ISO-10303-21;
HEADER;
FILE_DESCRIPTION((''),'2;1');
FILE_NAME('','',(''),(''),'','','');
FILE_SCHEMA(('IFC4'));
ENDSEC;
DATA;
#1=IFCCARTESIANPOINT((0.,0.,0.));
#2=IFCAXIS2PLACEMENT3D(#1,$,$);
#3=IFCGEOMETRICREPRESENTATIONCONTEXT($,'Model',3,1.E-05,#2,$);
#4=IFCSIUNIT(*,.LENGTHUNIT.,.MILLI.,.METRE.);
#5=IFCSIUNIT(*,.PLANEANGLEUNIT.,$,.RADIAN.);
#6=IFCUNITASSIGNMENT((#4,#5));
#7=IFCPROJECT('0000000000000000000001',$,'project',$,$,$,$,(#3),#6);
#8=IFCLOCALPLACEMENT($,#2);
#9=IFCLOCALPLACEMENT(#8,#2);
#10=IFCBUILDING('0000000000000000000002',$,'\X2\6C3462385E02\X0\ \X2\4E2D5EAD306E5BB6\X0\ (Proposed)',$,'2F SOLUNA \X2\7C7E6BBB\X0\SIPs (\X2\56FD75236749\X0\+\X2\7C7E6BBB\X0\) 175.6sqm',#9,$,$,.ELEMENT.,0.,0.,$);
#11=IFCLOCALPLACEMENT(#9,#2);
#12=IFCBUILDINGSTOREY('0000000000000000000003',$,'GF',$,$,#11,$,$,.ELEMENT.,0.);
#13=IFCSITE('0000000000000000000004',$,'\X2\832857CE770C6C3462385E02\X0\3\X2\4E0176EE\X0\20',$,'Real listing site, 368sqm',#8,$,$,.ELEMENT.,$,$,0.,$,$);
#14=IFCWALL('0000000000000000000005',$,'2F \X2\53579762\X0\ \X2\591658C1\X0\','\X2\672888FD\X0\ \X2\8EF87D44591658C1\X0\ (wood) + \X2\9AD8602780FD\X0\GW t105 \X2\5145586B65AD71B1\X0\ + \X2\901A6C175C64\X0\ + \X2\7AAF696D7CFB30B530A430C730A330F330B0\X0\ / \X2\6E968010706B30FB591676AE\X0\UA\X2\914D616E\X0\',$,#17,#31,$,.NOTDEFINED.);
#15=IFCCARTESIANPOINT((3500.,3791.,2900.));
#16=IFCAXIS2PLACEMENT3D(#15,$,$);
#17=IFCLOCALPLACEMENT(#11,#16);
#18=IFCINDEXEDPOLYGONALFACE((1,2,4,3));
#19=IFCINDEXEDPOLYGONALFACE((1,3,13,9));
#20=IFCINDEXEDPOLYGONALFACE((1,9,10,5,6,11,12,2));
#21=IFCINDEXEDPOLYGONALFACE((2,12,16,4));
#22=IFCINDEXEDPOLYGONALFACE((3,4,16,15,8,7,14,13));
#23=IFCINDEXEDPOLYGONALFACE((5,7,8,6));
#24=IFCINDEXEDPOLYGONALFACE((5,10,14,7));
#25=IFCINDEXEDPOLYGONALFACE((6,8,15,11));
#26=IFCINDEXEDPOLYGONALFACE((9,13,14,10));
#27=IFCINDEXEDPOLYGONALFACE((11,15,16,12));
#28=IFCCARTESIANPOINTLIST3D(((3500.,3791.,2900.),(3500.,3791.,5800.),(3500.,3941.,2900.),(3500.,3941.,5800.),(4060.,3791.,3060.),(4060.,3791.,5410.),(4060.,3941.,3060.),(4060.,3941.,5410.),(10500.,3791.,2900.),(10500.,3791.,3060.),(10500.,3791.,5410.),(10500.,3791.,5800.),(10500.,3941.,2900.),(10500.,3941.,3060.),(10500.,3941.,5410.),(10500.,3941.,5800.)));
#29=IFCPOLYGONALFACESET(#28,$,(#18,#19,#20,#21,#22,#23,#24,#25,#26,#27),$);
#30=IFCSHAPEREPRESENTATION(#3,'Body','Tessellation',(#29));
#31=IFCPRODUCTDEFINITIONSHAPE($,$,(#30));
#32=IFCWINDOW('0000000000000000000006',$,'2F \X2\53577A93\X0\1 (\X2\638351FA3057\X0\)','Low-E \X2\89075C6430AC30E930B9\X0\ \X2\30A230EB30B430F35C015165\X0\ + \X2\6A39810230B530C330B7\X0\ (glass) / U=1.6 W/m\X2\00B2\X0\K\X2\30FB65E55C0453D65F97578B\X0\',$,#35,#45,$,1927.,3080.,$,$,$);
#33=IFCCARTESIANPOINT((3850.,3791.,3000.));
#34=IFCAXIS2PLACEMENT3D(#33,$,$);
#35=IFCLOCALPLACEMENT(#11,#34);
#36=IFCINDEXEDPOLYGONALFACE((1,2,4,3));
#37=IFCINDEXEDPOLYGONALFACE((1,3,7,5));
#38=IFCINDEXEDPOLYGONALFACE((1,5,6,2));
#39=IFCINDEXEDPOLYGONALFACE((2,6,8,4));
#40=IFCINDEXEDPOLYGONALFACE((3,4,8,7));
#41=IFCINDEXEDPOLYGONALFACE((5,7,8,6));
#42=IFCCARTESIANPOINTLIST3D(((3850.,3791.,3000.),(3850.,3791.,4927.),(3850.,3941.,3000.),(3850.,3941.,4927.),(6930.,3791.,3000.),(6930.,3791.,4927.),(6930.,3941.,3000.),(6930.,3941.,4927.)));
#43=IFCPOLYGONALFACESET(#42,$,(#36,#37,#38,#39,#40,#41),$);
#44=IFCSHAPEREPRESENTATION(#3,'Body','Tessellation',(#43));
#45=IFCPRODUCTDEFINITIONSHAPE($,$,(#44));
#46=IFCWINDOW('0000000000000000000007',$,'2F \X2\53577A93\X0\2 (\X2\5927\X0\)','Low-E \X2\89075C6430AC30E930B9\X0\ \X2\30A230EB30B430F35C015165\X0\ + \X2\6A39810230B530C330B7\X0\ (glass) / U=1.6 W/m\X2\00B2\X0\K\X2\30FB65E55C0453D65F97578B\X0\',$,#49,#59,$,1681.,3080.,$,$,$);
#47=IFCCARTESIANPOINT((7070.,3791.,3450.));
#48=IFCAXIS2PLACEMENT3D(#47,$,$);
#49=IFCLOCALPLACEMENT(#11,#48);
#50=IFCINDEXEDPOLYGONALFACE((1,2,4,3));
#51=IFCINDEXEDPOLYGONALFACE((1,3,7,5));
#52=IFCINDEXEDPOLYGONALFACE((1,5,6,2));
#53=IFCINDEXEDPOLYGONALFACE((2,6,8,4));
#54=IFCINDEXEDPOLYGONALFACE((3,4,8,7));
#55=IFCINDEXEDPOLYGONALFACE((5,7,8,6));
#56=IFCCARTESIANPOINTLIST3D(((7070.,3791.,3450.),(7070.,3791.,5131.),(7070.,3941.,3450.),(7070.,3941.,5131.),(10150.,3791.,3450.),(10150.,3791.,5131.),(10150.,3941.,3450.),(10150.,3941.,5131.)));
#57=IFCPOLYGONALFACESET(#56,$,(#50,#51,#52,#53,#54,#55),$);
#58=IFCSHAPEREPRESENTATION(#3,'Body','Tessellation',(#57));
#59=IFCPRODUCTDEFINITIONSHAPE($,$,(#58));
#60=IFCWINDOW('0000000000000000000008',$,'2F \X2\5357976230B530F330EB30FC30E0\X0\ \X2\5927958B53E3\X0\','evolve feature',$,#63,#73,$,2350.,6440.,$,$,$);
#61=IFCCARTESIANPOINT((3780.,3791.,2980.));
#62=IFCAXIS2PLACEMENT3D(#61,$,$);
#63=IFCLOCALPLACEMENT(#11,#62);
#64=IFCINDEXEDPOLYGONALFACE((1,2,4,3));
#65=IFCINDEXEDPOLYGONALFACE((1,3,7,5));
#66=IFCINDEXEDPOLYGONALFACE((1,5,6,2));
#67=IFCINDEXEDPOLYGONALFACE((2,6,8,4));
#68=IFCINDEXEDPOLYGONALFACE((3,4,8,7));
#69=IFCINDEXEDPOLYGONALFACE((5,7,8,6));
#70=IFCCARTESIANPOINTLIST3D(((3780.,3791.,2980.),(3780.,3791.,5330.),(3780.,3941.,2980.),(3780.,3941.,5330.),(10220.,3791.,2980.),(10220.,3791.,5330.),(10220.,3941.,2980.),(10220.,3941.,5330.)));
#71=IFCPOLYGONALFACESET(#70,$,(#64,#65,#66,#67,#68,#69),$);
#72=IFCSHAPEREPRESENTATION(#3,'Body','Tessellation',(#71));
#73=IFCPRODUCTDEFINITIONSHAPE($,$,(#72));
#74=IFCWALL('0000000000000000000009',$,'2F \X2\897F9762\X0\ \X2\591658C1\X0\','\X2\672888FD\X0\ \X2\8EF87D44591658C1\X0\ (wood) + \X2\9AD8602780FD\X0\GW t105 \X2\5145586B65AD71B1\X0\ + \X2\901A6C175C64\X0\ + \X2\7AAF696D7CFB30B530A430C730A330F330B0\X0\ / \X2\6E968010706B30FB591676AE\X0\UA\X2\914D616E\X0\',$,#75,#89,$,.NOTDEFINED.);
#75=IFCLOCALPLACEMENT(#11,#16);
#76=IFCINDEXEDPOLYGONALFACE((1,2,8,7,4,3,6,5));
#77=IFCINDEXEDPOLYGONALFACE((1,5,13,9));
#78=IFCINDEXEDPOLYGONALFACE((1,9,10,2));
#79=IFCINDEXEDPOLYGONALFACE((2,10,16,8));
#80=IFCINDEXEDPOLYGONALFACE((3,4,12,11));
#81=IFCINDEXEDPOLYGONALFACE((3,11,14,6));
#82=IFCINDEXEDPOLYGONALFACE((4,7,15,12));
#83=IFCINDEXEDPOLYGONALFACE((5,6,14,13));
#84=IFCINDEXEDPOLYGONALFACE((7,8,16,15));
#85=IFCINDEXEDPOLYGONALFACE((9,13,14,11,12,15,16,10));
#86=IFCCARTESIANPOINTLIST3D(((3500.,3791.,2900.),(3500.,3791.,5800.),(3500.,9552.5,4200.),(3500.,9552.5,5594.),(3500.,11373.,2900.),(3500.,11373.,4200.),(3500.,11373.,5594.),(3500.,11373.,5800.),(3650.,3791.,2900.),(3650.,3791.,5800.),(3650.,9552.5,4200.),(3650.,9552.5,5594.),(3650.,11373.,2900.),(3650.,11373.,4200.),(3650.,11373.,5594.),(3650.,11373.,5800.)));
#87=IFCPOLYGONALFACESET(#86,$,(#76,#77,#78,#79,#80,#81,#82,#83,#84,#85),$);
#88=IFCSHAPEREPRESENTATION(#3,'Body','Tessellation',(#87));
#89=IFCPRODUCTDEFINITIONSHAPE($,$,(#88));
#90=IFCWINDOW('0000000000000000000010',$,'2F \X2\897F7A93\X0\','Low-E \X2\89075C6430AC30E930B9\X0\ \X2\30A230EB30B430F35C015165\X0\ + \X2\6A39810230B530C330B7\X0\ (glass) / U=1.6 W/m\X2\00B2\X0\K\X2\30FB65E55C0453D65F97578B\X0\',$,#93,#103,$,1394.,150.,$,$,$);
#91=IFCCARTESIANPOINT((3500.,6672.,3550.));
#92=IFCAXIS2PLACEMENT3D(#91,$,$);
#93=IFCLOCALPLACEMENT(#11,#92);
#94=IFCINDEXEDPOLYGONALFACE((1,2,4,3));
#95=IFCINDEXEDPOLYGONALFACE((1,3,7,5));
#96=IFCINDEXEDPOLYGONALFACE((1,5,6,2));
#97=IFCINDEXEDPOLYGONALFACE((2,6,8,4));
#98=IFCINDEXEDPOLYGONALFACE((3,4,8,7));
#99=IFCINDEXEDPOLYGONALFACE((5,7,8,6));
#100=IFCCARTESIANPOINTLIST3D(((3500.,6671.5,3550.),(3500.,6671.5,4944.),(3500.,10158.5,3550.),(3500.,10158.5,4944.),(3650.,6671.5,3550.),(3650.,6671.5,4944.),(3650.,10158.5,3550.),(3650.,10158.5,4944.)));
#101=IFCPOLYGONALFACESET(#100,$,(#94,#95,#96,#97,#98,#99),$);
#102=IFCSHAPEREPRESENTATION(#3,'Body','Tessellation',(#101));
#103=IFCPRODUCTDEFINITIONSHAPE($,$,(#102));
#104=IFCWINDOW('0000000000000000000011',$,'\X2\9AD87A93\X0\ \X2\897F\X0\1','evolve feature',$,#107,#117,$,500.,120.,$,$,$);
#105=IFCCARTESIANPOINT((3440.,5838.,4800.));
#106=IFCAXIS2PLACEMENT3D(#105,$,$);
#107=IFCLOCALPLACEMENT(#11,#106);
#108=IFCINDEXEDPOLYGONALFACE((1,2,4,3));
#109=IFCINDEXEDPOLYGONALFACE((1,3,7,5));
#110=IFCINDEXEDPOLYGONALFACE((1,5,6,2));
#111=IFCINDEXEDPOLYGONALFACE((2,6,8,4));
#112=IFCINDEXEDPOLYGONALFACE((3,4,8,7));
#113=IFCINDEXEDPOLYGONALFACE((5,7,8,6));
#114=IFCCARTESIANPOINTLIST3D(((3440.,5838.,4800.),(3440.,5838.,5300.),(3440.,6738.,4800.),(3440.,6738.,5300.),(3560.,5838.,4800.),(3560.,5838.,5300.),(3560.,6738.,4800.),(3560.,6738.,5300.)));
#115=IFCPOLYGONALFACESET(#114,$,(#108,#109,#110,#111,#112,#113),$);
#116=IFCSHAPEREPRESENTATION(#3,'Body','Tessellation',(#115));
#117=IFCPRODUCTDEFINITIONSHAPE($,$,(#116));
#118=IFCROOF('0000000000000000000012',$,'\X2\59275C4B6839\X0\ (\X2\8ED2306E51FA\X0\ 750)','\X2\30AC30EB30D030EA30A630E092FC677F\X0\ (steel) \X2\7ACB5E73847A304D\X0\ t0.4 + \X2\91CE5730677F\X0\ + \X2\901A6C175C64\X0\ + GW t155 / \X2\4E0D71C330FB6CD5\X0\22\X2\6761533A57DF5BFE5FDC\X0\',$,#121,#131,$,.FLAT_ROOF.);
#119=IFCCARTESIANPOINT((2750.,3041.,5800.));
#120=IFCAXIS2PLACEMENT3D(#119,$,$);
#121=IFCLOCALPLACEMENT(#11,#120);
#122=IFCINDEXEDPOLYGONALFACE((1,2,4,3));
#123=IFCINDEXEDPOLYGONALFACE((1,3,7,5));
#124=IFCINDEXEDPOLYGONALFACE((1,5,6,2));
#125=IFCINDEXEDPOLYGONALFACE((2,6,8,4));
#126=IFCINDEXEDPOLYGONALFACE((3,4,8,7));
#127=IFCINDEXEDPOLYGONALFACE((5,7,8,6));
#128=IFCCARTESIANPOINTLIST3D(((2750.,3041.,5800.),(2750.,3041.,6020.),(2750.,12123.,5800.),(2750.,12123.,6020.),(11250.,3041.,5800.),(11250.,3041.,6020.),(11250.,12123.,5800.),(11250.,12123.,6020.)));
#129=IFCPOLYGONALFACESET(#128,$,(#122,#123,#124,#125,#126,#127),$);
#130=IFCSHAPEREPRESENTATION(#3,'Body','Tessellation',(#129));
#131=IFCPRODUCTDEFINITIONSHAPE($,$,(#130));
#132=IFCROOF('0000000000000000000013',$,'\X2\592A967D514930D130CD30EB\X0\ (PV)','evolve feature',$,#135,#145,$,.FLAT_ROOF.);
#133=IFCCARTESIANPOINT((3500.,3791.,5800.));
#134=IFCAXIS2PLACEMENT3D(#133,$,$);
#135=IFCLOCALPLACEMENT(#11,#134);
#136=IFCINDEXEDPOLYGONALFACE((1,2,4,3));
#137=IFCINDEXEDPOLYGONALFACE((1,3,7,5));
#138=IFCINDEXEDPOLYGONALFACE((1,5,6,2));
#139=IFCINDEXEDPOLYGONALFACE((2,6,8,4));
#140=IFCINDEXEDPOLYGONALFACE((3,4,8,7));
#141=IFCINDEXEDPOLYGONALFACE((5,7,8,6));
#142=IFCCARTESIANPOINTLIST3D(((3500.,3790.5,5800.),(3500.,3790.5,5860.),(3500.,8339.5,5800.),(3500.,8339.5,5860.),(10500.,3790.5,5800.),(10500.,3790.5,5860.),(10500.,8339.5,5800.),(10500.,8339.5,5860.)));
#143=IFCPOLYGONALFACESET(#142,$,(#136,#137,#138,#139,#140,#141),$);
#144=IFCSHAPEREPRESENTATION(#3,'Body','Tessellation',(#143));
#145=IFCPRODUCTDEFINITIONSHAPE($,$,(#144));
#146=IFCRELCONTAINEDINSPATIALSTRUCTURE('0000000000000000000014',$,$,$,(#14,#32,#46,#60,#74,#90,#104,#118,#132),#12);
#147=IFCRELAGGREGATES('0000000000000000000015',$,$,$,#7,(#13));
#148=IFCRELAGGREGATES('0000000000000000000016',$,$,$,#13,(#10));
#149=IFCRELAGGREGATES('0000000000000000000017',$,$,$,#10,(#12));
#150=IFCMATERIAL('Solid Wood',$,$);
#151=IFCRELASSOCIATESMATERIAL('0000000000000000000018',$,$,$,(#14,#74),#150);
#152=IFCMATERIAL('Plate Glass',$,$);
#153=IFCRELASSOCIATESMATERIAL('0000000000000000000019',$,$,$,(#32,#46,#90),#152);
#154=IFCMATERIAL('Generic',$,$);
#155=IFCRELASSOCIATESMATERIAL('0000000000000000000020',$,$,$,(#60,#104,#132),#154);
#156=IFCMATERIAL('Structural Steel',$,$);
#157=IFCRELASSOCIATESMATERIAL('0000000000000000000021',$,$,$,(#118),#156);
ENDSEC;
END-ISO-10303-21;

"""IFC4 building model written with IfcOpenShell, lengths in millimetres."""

from ifc_helpers import new_model, si_unit, frame, frame_2d, origin, place, context, project, spatial, rectangle, extrude, material, element, fill, save


model = new_model("IFC4")

# Units and contexts
model_context = context("Model", 3, precision=1e-05, world=origin())
ifc_project = project(units=[si_unit("LENGTHUNIT", "METRE", prefix="MILLI"), si_unit("PLANEANGLEUNIT", "RADIAN")], contexts=[model_context])

# Site, building, storey
site_placement = place(None, origin())
site = spatial("IfcSite", under=ifc_project, at=site_placement, Name="茨城県水戸市3丁目20", ObjectType="Real listing site, 368sqm", CompositionType="ELEMENT", RefElevation=0.0)
building_placement = place(site_placement, origin())
building = spatial("IfcBuilding", under=site, at=building_placement, Name="水戸市 中庭の家 (Proposed)", ObjectType="2F SOLUNA 籾殻SIPs (国産杉+籾殻) 175.6sqm", CompositionType="ELEMENT", ElevationOfRefHeight=0.0, ElevationOfTerrain=0.0)
storey_placement = place(building_placement, origin())
storey = spatial("IfcBuildingStorey", under=building, at=storey_placement, Name="GF", CompositionType="ELEMENT", Elevation=0.0)

# Shared definitions
ifc_material_1 = material(Name="Solid Wood")
ifc_material_2 = material(Name="Generic")

# Shared definitions
ifc_material_3 = material(Name="Plate Glass")

# Walls, openings, windows
wall_1_placement = place(storey_placement, frame((3500.0, 3791.0, 2900.0)))
wall_1 = element("IfcWall", 1, at=wall_1_placement, inside=storey, material=ifc_material_1, Name="2F 南面 外壁", Description="木製 軸組外壁 (wood) + 高性能GW t105 充填断熱 + 通気層 + 窯業系サイディング / 準耐火・外皮UA配慮", PredefinedType="NOTDEFINED", context=model_context, shape_type="SweptSolid", body=[
    extrude(rectangle(XDim=7000.0, YDim=150.0, at=frame_2d((3500.0, 75.0))), frame((3500.0, 3791.0, 2900.0)), (0.0, 0.0, 1.0), 2900.0),
])
opening_1_placement = place(storey_placement, frame((3850.0, 3791.0, 3000.0)))
opening_1 = element("IfcOpeningElement", 2, at=opening_1_placement, cuts=wall_1, PredefinedType="NOTDEFINED", context=model_context, shape_type="SweptSolid", body=[
    extrude(rectangle(XDim=3080.0, YDim=150.0, at=frame_2d((1540.0, 75.0))), frame((3850.0, 3791.0, 3000.0)), (0.0, 0.0, 1.0), 1927.0),
])
opening_2_placement = place(storey_placement, frame((7070.0, 3791.0, 3450.0)))
opening_2 = element("IfcOpeningElement", 3, at=opening_2_placement, cuts=wall_1, PredefinedType="NOTDEFINED", context=model_context, shape_type="SweptSolid", body=[
    extrude(rectangle(XDim=3080.0, YDim=150.0, at=frame_2d((1540.0, 75.0))), frame((7070.0, 3791.0, 3450.0)), (0.0, 0.0, 1.0), 1681.0),
])
opening_3_placement = place(storey_placement, frame((3780.0, 3791.0, 2980.0)))
opening_3 = element("IfcOpeningElement", 4, at=opening_3_placement, cuts=wall_1, PredefinedType="NOTDEFINED", context=model_context, shape_type="SweptSolid", body=[
    extrude(rectangle(XDim=6440.0, YDim=150.0, at=frame_2d((3220.0, 75.0))), frame((3780.0, 3791.0, 2980.0)), (0.0, 0.0, 1.0), 2350.0),
])
window_1_placement = place(storey_placement, frame((3850.0, 3791.0, 3000.0)))
window_1 = element("IfcWindow", 5, at=window_1_placement, inside=storey, material=ifc_material_3, Name="2F 南窓1 (掃出し)", Description="Low-E 複層ガラス アルゴン封入 + 樹脂サッシ (glass) / U=1.6 W/m²K・日射取得型", OverallHeight=1927.0, OverallWidth=3080.0, context=model_context, shape_type="SweptSolid", body=[
    extrude(rectangle(XDim=3080.0, YDim=150.0, at=frame_2d((1540.0, 75.0))), frame((3850.0, 3791.0, 3000.0)), (0.0, 0.0, 1.0), 1927.0),
])
fill(opening_1, window_1)
window_2_placement = place(storey_placement, frame((7070.0, 3791.0, 3450.0)))
window_2 = element("IfcWindow", 6, at=window_2_placement, inside=storey, material=ifc_material_3, Name="2F 南窓2 (大)", Description="Low-E 複層ガラス アルゴン封入 + 樹脂サッシ (glass) / U=1.6 W/m²K・日射取得型", OverallHeight=1681.0, OverallWidth=3080.0, context=model_context, shape_type="SweptSolid", body=[
    extrude(rectangle(XDim=3080.0, YDim=150.0, at=frame_2d((1540.0, 75.0))), frame((7070.0, 3791.0, 3450.0)), (0.0, 0.0, 1.0), 1681.0),
])
fill(opening_2, window_2)
window_3_placement = place(storey_placement, frame((3780.0, 3791.0, 2980.0)))
window_3 = element("IfcWindow", 7, at=window_3_placement, inside=storey, material=ifc_material_2, Name="2F 南面サンルーム 大開口", Description="evolve feature", OverallHeight=2350.0, OverallWidth=6440.0, context=model_context, shape_type="SweptSolid", body=[
    extrude(rectangle(XDim=6440.0, YDim=150.0, at=frame_2d((3220.0, 75.0))), frame((3780.0, 3791.0, 2980.0)), (0.0, 0.0, 1.0), 2350.0),
])
fill(opening_3, window_3)
wall_2_placement = place(storey_placement, frame((3500.0, 3791.0, 2900.0)))
wall_2 = element("IfcWall", 8, at=wall_2_placement, inside=storey, material=ifc_material_1, Name="2F 西面 外壁", Description="木製 軸組外壁 (wood) + 高性能GW t105 充填断熱 + 通気層 + 窯業系サイディング / 準耐火・外皮UA配慮", PredefinedType="NOTDEFINED", context=model_context, shape_type="SweptSolid", body=[
    extrude(rectangle(XDim=150.0, YDim=7582.0, at=frame_2d((75.0, 3791.0))), frame((3500.0, 3791.0, 2900.0)), (0.0, 0.0, 1.0), 2900.0),
])
opening_4_placement = place(storey_placement, frame((3500.0, 6672.0, 3550.0)))
opening_4 = element("IfcOpeningElement", 9, at=opening_4_placement, cuts=wall_2, PredefinedType="NOTDEFINED", context=model_context, shape_type="SweptSolid", body=[
    extrude(rectangle(XDim=150.0, YDim=3487.0, at=frame_2d((75.0, 1743.0))), frame((3500.0, 6672.0, 3550.0)), (0.0, 0.0, 1.0), 1394.0),
])
opening_5_placement = place(storey_placement, frame((3440.0, 5838.0, 4800.0)))
opening_5 = element("IfcOpeningElement", 10, at=opening_5_placement, cuts=wall_2, PredefinedType="NOTDEFINED", context=model_context, shape_type="SweptSolid", body=[
    extrude(rectangle(XDim=120.0, YDim=900.0, at=frame_2d((60.0, 450.0))), frame((3440.0, 5838.0, 4800.0)), (0.0, 0.0, 1.0), 500.0),
])
window_4_placement = place(storey_placement, frame((3500.0, 6672.0, 3550.0)))
window_4 = element("IfcWindow", 11, at=window_4_placement, inside=storey, material=ifc_material_3, Name="2F 西窓", Description="Low-E 複層ガラス アルゴン封入 + 樹脂サッシ (glass) / U=1.6 W/m²K・日射取得型", OverallHeight=1394.0, OverallWidth=150.0, context=model_context, shape_type="SweptSolid", body=[
    extrude(rectangle(XDim=150.0, YDim=3487.0, at=frame_2d((75.0, 1743.0))), frame((3500.0, 6672.0, 3550.0)), (0.0, 0.0, 1.0), 1394.0),
])
fill(opening_4, window_4)
window_5_placement = place(storey_placement, frame((3440.0, 5838.0, 4800.0)))
window_5 = element("IfcWindow", 12, at=window_5_placement, inside=storey, material=ifc_material_2, Name="高窓 西1", Description="evolve feature", OverallHeight=500.0, OverallWidth=120.0, context=model_context, shape_type="SweptSolid", body=[
    extrude(rectangle(XDim=120.0, YDim=900.0, at=frame_2d((60.0, 450.0))), frame((3440.0, 5838.0, 4800.0)), (0.0, 0.0, 1.0), 500.0),
])
fill(opening_5, window_5)

# Roofs
ifc_material_4 = material(Name="Structural Steel")
roof_1_placement = place(storey_placement, frame((2750.0, 3041.0, 5800.0)))
element("IfcRoof", 13, at=roof_1_placement, inside=storey, material=ifc_material_4, Name="大屋根 (軒の出 750)", Description="ガルバリウム鋼板 (steel) 立平葺き t0.4 + 野地板 + 通気層 + GW t155 / 不燃・法22条区域対応", PredefinedType="FLAT_ROOF", context=model_context, shape_type="SweptSolid", body=[
    extrude(rectangle(XDim=8500.0, YDim=9082.0, at=frame_2d((4250.0, 4541.0))), frame((2750.0, 3041.0, 5800.0)), (0.0, 0.0, 1.0), 220.0),
])
roof_2_placement = place(storey_placement, frame((3500.0, 3791.0, 5800.0)))
element("IfcRoof", 14, at=roof_2_placement, inside=storey, material=ifc_material_2, Name="太陽光パネル (PV)", Description="evolve feature", PredefinedType="FLAT_ROOF", context=model_context, shape_type="SweptSolid", body=[
    extrude(rectangle(XDim=7000.0, YDim=4549.0, at=frame_2d((3500.0, 2274.0))), frame((3500.0, 3791.0, 5800.0)), (0.0, 0.0, 1.0), 60.0),
])

save(model, "model.ifc")
